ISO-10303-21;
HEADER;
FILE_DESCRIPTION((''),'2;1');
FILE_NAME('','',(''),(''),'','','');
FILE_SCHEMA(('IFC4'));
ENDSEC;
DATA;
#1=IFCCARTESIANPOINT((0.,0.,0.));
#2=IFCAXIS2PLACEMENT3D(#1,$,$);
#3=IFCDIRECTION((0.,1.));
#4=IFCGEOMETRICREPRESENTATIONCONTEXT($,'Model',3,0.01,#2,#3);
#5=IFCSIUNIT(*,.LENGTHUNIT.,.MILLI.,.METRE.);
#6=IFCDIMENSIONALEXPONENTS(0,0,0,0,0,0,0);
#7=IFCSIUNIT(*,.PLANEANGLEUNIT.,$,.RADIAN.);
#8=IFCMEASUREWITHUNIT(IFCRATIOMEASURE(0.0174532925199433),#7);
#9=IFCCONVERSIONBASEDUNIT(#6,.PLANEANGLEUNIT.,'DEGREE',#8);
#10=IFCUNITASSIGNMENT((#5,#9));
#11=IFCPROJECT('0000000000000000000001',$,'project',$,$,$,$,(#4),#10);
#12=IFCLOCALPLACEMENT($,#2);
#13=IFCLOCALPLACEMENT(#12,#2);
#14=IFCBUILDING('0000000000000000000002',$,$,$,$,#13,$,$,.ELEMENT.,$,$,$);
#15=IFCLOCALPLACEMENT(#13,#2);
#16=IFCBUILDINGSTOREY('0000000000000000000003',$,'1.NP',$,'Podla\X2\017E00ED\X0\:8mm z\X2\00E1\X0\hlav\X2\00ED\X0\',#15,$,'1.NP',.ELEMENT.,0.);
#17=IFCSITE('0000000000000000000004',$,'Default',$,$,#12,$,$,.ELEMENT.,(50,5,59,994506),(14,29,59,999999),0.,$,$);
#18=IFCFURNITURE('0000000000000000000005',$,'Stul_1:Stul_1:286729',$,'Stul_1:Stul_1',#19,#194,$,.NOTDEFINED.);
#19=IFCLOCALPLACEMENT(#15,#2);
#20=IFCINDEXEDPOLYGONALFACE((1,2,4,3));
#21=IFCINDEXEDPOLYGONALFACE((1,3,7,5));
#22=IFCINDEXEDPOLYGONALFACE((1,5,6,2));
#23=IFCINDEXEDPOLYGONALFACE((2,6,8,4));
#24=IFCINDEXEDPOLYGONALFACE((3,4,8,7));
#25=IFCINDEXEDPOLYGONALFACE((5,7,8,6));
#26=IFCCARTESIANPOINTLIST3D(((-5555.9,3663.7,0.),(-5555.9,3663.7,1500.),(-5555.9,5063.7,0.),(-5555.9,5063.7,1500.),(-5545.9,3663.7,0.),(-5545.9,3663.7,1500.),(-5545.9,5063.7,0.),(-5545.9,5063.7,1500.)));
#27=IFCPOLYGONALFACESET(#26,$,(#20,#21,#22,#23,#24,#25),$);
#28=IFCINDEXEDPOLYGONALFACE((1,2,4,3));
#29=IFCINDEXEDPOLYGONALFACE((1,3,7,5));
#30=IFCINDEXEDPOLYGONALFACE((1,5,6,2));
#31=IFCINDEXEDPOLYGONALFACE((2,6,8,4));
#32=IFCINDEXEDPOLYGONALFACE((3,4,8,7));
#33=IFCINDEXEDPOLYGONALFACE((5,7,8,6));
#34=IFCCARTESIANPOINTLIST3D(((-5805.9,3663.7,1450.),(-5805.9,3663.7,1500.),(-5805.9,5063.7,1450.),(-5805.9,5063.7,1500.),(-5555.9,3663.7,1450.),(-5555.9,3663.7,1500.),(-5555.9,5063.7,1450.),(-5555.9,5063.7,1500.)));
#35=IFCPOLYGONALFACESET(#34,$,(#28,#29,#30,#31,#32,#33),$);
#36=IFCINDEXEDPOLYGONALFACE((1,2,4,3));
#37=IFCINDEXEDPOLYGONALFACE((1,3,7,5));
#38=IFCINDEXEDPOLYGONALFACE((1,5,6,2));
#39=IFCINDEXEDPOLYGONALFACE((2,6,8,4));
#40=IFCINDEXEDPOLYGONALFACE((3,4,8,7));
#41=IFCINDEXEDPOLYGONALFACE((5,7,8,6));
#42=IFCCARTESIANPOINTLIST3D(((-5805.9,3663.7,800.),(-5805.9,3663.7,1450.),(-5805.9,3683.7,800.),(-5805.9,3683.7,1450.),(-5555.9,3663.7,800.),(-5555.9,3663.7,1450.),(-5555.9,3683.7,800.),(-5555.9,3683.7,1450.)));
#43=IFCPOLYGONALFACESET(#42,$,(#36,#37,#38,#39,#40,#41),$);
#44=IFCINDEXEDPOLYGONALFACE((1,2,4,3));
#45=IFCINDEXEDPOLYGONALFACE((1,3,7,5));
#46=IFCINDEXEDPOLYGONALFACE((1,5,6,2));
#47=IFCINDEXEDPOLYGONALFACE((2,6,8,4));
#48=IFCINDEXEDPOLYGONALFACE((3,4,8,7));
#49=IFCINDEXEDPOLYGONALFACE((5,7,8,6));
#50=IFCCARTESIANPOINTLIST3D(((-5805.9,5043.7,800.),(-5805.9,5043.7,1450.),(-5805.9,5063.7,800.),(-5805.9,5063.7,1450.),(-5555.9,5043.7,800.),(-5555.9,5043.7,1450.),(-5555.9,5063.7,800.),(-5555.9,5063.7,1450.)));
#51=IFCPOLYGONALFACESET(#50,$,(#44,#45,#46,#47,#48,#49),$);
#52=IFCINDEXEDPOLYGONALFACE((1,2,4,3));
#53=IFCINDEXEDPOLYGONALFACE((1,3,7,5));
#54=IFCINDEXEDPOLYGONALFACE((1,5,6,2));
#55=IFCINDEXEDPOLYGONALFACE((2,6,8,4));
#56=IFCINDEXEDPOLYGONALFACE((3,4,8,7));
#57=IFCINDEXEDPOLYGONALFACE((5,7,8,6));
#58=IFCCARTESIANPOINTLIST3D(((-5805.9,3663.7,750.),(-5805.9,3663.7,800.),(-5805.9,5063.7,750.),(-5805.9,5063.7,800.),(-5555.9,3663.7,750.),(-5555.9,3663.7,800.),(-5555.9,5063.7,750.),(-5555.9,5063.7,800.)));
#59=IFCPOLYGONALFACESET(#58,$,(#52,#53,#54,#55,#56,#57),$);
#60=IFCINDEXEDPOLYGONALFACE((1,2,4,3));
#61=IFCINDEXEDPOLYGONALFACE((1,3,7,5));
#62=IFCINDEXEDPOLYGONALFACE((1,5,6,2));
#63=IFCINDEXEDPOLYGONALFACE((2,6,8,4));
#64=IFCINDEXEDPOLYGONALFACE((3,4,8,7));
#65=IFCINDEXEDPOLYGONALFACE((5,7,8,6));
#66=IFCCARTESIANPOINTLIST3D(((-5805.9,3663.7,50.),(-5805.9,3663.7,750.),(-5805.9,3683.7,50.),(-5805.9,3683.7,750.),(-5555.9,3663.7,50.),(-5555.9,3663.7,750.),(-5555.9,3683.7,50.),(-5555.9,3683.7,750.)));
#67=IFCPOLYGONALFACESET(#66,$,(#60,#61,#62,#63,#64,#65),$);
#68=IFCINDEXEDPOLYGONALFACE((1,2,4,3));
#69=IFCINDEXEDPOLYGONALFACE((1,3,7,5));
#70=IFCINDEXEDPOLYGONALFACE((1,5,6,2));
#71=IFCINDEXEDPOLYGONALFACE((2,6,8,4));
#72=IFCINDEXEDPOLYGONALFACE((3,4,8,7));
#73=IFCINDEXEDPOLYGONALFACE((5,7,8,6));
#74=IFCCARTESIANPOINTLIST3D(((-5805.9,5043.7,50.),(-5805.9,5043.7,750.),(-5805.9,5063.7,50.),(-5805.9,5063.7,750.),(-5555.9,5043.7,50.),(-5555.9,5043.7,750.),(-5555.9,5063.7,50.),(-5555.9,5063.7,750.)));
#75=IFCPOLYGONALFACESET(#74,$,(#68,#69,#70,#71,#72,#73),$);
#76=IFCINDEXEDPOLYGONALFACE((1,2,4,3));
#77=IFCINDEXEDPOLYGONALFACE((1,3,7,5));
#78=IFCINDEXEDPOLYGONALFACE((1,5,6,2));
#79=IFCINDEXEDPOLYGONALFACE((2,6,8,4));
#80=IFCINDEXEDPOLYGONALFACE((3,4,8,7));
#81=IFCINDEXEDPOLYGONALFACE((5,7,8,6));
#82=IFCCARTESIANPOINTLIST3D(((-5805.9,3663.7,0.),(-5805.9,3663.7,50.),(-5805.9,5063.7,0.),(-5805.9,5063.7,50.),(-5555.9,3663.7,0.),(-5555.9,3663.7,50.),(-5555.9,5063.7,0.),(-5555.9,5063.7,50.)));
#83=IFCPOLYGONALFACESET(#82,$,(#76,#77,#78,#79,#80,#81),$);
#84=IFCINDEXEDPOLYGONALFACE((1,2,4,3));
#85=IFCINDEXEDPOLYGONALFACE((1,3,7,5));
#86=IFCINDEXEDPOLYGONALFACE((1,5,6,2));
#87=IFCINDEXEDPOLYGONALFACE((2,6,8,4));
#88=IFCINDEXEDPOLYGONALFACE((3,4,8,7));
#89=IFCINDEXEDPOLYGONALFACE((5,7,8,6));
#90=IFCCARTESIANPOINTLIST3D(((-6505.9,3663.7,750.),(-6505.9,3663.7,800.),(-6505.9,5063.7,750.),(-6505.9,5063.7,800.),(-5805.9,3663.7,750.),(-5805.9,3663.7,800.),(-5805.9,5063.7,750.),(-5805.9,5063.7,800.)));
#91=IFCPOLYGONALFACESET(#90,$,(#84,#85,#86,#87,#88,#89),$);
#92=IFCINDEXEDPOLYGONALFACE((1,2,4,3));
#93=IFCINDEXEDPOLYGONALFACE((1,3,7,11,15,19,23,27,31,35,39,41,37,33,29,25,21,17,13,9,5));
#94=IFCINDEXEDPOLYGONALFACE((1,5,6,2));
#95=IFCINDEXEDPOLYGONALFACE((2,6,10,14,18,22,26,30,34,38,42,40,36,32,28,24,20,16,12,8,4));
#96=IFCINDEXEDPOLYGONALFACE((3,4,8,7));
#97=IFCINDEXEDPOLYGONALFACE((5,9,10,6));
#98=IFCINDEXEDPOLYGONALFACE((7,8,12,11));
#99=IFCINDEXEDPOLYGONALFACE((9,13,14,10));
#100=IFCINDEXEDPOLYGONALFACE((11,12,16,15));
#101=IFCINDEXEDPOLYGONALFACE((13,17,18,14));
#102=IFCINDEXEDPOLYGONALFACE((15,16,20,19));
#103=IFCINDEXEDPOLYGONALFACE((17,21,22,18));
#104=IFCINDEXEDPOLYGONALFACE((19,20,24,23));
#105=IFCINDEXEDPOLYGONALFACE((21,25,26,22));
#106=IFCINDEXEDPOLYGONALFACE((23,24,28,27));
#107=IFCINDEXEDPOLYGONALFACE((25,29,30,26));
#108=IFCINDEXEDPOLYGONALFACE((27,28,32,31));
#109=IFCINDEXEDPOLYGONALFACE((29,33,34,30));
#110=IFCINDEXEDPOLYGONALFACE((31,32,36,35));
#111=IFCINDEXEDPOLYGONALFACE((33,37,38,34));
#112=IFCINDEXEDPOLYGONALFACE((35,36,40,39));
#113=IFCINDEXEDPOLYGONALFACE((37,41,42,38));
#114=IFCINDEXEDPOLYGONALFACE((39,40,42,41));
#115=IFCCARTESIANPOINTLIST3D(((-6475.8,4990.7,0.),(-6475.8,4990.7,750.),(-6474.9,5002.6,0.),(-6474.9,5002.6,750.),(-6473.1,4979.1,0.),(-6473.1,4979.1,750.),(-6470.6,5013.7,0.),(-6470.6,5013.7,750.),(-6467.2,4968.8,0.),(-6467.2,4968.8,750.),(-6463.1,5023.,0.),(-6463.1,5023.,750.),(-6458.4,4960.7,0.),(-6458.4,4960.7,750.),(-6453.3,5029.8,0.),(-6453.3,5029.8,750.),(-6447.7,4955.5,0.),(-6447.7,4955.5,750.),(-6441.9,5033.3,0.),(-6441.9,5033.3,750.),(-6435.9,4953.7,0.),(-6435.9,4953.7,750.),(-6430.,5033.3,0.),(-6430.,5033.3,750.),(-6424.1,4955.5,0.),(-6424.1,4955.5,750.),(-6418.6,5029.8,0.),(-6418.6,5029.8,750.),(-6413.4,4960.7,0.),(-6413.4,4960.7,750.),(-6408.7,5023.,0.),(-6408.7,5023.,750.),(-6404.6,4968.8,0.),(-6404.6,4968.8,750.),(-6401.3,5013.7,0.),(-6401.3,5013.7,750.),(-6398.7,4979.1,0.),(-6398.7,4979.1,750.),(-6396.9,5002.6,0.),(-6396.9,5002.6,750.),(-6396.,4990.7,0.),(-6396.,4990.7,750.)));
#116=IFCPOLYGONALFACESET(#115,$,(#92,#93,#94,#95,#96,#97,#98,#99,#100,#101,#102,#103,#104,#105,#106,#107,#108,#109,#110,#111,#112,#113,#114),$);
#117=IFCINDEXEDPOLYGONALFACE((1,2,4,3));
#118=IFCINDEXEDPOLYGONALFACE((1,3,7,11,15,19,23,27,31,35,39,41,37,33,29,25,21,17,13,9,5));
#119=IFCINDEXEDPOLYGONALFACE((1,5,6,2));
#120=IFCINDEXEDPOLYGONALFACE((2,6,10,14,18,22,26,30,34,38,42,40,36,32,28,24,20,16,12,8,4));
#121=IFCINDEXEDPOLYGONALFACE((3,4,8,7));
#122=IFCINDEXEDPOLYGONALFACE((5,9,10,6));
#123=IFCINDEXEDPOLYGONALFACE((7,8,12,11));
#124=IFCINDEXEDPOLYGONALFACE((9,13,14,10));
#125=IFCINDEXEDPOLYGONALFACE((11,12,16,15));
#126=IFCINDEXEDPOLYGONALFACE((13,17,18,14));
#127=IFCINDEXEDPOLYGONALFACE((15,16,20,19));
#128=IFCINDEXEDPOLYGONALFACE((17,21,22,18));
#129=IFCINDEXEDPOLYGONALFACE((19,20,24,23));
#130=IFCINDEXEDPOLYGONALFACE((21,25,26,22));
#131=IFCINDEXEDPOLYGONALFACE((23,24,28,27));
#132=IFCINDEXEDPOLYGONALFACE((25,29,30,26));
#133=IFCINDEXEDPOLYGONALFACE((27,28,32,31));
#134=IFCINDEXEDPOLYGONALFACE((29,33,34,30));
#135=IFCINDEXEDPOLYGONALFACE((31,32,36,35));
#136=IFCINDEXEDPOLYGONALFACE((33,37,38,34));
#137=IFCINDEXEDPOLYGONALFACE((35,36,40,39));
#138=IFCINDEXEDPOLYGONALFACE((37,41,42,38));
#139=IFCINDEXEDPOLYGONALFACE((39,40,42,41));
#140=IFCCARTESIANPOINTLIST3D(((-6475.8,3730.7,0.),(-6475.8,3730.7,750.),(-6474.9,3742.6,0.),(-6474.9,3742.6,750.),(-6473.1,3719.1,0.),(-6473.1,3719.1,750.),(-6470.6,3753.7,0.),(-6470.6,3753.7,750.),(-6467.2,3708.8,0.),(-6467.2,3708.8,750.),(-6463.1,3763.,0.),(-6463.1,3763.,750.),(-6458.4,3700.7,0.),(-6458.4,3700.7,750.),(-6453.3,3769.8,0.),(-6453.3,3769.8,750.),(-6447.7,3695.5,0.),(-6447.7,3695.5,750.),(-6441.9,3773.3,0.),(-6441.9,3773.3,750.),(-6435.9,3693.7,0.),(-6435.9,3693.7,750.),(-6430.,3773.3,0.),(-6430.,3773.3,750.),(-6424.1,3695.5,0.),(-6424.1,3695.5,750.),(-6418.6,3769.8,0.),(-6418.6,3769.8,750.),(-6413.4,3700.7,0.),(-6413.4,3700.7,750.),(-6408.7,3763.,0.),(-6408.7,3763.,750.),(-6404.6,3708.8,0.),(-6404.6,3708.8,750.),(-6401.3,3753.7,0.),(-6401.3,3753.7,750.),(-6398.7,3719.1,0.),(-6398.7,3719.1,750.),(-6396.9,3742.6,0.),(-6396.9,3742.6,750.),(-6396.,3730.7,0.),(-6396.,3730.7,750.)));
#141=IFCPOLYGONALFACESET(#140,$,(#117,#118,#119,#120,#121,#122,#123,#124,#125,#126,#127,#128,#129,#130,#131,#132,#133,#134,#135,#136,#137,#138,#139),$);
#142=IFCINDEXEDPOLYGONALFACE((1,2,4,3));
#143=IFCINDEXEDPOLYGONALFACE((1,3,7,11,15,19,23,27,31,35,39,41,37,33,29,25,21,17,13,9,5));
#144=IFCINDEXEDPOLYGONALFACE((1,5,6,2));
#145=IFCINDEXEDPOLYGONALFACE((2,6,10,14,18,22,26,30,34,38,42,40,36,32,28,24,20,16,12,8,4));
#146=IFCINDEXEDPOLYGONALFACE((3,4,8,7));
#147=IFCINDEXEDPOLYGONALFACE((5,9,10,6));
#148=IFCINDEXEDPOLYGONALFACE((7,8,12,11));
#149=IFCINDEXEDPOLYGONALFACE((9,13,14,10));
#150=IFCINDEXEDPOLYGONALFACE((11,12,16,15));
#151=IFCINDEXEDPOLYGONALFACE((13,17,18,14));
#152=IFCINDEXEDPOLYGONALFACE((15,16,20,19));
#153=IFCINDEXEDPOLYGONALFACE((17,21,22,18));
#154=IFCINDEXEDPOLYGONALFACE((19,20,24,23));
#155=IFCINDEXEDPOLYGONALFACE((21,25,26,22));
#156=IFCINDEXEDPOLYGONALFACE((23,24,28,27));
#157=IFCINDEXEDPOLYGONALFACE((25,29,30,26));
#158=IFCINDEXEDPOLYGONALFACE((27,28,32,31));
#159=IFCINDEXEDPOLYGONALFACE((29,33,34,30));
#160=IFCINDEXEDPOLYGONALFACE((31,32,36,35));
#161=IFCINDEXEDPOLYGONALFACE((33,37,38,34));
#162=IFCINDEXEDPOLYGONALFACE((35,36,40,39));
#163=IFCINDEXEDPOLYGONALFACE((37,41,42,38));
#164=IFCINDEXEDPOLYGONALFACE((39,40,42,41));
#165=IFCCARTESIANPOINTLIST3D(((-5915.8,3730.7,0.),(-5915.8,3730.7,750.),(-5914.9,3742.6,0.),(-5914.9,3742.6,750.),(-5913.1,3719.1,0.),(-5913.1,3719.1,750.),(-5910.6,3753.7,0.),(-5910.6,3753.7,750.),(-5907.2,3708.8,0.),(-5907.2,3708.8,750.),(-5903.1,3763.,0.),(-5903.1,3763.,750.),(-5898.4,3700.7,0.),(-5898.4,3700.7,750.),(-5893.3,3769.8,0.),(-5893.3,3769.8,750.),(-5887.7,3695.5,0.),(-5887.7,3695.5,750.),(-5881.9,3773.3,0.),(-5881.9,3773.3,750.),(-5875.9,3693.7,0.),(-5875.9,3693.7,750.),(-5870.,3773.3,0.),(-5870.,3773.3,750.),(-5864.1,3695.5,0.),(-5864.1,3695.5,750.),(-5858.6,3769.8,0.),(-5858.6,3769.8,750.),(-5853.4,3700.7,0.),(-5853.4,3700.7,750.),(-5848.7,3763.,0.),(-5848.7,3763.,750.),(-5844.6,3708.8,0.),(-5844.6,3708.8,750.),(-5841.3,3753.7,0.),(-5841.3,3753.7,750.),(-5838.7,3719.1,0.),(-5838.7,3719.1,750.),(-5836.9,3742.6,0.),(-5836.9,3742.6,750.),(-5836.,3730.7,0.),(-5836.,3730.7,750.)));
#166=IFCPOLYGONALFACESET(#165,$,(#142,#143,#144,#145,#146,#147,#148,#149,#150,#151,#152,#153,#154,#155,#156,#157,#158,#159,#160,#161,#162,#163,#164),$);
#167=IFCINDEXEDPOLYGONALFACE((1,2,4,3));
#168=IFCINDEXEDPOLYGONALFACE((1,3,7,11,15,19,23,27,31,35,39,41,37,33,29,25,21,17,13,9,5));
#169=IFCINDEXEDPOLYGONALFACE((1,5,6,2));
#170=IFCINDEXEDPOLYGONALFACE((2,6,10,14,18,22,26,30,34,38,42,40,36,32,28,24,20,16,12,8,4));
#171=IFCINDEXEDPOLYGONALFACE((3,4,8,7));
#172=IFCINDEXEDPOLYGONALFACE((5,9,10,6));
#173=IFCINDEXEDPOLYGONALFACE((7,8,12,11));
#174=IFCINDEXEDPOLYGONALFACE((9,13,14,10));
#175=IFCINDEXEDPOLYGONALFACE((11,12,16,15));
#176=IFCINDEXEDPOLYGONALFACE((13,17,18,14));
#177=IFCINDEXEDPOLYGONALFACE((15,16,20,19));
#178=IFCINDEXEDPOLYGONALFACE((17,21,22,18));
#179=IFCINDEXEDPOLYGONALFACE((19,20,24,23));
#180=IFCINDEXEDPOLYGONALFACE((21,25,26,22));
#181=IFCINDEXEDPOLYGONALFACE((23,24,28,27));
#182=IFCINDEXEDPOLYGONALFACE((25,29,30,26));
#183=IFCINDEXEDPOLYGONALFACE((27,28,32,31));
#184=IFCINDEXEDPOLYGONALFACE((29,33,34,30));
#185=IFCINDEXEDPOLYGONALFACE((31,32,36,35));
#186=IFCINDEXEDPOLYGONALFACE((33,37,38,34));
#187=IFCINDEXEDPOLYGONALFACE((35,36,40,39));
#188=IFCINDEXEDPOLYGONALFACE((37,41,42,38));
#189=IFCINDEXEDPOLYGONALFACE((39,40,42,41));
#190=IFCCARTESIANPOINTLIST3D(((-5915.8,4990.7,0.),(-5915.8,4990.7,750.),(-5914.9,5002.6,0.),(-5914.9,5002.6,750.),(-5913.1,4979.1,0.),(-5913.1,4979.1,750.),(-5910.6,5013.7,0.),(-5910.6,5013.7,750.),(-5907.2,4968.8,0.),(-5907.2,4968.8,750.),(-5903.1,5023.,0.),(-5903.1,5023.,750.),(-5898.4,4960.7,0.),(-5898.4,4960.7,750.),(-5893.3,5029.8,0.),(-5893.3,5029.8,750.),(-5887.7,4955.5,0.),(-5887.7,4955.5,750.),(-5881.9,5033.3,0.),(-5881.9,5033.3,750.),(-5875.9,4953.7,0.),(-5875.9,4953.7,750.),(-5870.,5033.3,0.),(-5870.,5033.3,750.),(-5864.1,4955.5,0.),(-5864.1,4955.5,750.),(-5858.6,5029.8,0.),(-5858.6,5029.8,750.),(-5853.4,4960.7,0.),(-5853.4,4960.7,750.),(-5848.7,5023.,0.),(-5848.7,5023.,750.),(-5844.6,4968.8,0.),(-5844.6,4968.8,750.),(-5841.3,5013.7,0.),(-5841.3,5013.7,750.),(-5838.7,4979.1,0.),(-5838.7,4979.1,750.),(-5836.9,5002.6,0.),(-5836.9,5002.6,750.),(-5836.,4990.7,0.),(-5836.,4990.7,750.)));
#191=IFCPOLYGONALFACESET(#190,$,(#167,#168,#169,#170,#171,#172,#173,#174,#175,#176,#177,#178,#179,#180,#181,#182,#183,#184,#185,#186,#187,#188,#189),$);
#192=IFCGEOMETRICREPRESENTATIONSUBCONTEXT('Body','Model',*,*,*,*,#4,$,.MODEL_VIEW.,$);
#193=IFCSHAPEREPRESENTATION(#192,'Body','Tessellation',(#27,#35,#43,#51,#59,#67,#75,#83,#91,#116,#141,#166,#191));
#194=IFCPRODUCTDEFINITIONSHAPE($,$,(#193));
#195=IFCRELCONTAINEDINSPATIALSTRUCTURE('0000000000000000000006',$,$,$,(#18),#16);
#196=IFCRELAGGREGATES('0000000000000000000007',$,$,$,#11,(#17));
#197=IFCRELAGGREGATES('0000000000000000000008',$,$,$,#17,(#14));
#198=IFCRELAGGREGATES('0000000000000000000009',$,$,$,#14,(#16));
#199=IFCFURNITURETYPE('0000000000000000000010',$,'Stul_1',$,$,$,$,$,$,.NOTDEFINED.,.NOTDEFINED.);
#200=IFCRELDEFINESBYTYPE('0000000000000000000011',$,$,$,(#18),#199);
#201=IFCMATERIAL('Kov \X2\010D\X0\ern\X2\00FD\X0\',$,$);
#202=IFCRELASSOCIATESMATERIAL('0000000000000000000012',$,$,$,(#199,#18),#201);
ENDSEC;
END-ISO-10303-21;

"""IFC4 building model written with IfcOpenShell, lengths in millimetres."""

from ifc_helpers import new_model, entity, si_unit, converted_unit, direction, frame, frame_2d, origin, origin_2d_with_axis, place, context, subcontext, project, spatial, rectangle, circle, extrude, source, transform, mapped, material, type_object, type_shapes, element, save


model = new_model("IFC4")

# Units and contexts
model_context = context("Model", 3, precision=0.01, world=origin(), true_north=direction((0.0, 1.0)))
body_context = subcontext(model_context, "Body", "Model", "MODEL_VIEW")
ifc_project = project(units=[si_unit("LENGTHUNIT", "METRE", prefix="MILLI"), converted_unit("PLANEANGLEUNIT", "DEGREE", entity("IfcRatioMeasure", 0.0174532925199433), si_unit("PLANEANGLEUNIT", "RADIAN"), dimensions=[0, 0, 0, 0, 0, 0, 0])], contexts=[model_context])

# Site, building, storey
site_placement = place(None, origin())
site = spatial("IfcSite", under=ifc_project, at=site_placement, Name="Default", CompositionType="ELEMENT", RefLatitude=(50, 5, 59, 994506), RefLongitude=(14, 29, 59, 999999), RefElevation=0.0)
building_placement = place(site_placement, origin())
building = spatial("IfcBuilding", under=site, at=building_placement, CompositionType="ELEMENT")
storey_placement = place(building_placement, origin())
storey = spatial("IfcBuildingStorey", under=building, at=storey_placement, Name="1.NP", ObjectType="Podlaží:8mm záhlaví", LongName="1.NP", CompositionType="ELEMENT", Elevation=0.0)

# Furniture
ifc_material_1 = material(Name="Kov černý")
furniture_type = type_object("IfcFurnitureType", Name="Stul_1", AssemblyPlace="NOTDEFINED", PredefinedType="NOTDEFINED", material=ifc_material_1)
shared_shape_1 = source(origin(), body_context, "Body", "SweptSolid", [
    extrude(rectangle(XDim=1400.0, YDim=10.0, at=origin_2d_with_axis()), frame((0.0, 605.0, 0.0), z_axis=(0.0, 0.0, 1.0), x_axis=(-1.0, 0.0, 0.0)), (0.0, 0.0, 1.0), 1500.0),
    extrude(rectangle(XDim=1400.0, YDim=250.0, at=frame_2d((0.0, 0.0), x_axis=(1.0, 0.0))), frame((0.0, 475.0, 1450.0), z_axis=(0.0, 0.0, 1.0), x_axis=(-1.0, 0.0, 0.0)), (0.0, 0.0, 1.0), 50.0),
    extrude(rectangle(XDim=20.0, YDim=250.0, at=origin_2d_with_axis()), frame((690.0, 475.0, 800.0), z_axis=(0.0, 0.0, 1.0), x_axis=(-1.0, 0.0, 0.0)), (0.0, 0.0, 1.0), 650.0),
    extrude(rectangle(XDim=20.0, YDim=250.0, at=frame_2d((0.0, 0.0), x_axis=(1.0, 0.0))), frame((-690.0, 475.0, 800.0), z_axis=(0.0, 0.0, 1.0), x_axis=(-1.0, 0.0, 0.0)), (0.0, 0.0, 1.0), 650.0),
    extrude(rectangle(XDim=1400.0, YDim=250.0, at=origin_2d_with_axis()), frame((0.0, 475.0, 750.0), z_axis=(0.0, 0.0, 1.0), x_axis=(-1.0, 0.0, 0.0)), (0.0, 0.0, 1.0), 50.0),
    extrude(rectangle(XDim=20.0, YDim=250.0, at=origin_2d_with_axis()), frame((690.0, 475.0, 50.0), z_axis=(0.0, 0.0, 1.0), x_axis=(-1.0, 0.0, 0.0)), (0.0, 0.0, 1.0), 700.0),
    extrude(rectangle(XDim=20.0, YDim=250.0, at=frame_2d((0.0, 0.0), x_axis=(1.0, 0.0))), frame((-690.0, 475.0, 50.0), z_axis=(0.0, 0.0, 1.0), x_axis=(-1.0, 0.0, 0.0)), (0.0, 0.0, 1.0), 700.0),
    extrude(rectangle(XDim=1400.0, YDim=250.0, at=origin_2d_with_axis()), frame((0.0, 475.0, 0.0), z_axis=(0.0, 0.0, 1.0), x_axis=(-1.0, 0.0, 0.0)), (0.0, 0.0, 1.0), 50.0),
    extrude(rectangle(XDim=1400.0, YDim=700.0, at=origin_2d_with_axis()), frame((0.0, 0.0, 750.0), z_axis=(0.0, 0.0, 1.0), x_axis=(-1.0, 0.0, 0.0)), (0.0, 0.0, 1.0), 50.0),
    extrude(circle(Radius=40.0, at=frame_2d((0.0, 0.0), x_axis=(1.0, 0.0))), frame((-630.0, -280.0, 0.0)), (0.0, 0.0, 1.0), 750.0),
    extrude(circle(Radius=40.0, at=frame_2d((0.0, 0.0), x_axis=(1.0, 0.0))), frame((630.0, -280.0, 0.0)), (0.0, 0.0, 1.0), 750.0),
    extrude(circle(Radius=40.0, at=frame_2d((0.0, 0.0), x_axis=(1.0, 0.0))), frame((630.0, 280.0, 0.0)), (0.0, 0.0, 1.0), 750.0),
    extrude(circle(Radius=40.0, at=frame_2d((0.0, 0.0), x_axis=(1.0, 0.0))), frame((-630.0, 280.0, 0.0)), (0.0, 0.0, 1.0), 750.0),
])
type_shapes(furniture_type, [shared_shape_1])
for number, where, z_axis, x_axis, name in (
    (1, (-6155.9, 4363.7, 0.0), (0.0, 0.0, 1.0), (0.0, -1.0, 0.0), "Stul_1:Stul_1:286729"),
):
    element("IfcFurniture", number, at=place(storey_placement, frame(where, z_axis=z_axis, x_axis=x_axis)), inside=storey, type_object=furniture_type, material=ifc_material_1, Name=name, ObjectType="Stul_1:Stul_1", PredefinedType="NOTDEFINED", context=body_context, shape_type="MappedRepresentation", body=[
        mapped(shared_shape_1, transform((0.0, 0.0, 0.0), scale=1.0)),
    ])

save(model, "model.ifc")
